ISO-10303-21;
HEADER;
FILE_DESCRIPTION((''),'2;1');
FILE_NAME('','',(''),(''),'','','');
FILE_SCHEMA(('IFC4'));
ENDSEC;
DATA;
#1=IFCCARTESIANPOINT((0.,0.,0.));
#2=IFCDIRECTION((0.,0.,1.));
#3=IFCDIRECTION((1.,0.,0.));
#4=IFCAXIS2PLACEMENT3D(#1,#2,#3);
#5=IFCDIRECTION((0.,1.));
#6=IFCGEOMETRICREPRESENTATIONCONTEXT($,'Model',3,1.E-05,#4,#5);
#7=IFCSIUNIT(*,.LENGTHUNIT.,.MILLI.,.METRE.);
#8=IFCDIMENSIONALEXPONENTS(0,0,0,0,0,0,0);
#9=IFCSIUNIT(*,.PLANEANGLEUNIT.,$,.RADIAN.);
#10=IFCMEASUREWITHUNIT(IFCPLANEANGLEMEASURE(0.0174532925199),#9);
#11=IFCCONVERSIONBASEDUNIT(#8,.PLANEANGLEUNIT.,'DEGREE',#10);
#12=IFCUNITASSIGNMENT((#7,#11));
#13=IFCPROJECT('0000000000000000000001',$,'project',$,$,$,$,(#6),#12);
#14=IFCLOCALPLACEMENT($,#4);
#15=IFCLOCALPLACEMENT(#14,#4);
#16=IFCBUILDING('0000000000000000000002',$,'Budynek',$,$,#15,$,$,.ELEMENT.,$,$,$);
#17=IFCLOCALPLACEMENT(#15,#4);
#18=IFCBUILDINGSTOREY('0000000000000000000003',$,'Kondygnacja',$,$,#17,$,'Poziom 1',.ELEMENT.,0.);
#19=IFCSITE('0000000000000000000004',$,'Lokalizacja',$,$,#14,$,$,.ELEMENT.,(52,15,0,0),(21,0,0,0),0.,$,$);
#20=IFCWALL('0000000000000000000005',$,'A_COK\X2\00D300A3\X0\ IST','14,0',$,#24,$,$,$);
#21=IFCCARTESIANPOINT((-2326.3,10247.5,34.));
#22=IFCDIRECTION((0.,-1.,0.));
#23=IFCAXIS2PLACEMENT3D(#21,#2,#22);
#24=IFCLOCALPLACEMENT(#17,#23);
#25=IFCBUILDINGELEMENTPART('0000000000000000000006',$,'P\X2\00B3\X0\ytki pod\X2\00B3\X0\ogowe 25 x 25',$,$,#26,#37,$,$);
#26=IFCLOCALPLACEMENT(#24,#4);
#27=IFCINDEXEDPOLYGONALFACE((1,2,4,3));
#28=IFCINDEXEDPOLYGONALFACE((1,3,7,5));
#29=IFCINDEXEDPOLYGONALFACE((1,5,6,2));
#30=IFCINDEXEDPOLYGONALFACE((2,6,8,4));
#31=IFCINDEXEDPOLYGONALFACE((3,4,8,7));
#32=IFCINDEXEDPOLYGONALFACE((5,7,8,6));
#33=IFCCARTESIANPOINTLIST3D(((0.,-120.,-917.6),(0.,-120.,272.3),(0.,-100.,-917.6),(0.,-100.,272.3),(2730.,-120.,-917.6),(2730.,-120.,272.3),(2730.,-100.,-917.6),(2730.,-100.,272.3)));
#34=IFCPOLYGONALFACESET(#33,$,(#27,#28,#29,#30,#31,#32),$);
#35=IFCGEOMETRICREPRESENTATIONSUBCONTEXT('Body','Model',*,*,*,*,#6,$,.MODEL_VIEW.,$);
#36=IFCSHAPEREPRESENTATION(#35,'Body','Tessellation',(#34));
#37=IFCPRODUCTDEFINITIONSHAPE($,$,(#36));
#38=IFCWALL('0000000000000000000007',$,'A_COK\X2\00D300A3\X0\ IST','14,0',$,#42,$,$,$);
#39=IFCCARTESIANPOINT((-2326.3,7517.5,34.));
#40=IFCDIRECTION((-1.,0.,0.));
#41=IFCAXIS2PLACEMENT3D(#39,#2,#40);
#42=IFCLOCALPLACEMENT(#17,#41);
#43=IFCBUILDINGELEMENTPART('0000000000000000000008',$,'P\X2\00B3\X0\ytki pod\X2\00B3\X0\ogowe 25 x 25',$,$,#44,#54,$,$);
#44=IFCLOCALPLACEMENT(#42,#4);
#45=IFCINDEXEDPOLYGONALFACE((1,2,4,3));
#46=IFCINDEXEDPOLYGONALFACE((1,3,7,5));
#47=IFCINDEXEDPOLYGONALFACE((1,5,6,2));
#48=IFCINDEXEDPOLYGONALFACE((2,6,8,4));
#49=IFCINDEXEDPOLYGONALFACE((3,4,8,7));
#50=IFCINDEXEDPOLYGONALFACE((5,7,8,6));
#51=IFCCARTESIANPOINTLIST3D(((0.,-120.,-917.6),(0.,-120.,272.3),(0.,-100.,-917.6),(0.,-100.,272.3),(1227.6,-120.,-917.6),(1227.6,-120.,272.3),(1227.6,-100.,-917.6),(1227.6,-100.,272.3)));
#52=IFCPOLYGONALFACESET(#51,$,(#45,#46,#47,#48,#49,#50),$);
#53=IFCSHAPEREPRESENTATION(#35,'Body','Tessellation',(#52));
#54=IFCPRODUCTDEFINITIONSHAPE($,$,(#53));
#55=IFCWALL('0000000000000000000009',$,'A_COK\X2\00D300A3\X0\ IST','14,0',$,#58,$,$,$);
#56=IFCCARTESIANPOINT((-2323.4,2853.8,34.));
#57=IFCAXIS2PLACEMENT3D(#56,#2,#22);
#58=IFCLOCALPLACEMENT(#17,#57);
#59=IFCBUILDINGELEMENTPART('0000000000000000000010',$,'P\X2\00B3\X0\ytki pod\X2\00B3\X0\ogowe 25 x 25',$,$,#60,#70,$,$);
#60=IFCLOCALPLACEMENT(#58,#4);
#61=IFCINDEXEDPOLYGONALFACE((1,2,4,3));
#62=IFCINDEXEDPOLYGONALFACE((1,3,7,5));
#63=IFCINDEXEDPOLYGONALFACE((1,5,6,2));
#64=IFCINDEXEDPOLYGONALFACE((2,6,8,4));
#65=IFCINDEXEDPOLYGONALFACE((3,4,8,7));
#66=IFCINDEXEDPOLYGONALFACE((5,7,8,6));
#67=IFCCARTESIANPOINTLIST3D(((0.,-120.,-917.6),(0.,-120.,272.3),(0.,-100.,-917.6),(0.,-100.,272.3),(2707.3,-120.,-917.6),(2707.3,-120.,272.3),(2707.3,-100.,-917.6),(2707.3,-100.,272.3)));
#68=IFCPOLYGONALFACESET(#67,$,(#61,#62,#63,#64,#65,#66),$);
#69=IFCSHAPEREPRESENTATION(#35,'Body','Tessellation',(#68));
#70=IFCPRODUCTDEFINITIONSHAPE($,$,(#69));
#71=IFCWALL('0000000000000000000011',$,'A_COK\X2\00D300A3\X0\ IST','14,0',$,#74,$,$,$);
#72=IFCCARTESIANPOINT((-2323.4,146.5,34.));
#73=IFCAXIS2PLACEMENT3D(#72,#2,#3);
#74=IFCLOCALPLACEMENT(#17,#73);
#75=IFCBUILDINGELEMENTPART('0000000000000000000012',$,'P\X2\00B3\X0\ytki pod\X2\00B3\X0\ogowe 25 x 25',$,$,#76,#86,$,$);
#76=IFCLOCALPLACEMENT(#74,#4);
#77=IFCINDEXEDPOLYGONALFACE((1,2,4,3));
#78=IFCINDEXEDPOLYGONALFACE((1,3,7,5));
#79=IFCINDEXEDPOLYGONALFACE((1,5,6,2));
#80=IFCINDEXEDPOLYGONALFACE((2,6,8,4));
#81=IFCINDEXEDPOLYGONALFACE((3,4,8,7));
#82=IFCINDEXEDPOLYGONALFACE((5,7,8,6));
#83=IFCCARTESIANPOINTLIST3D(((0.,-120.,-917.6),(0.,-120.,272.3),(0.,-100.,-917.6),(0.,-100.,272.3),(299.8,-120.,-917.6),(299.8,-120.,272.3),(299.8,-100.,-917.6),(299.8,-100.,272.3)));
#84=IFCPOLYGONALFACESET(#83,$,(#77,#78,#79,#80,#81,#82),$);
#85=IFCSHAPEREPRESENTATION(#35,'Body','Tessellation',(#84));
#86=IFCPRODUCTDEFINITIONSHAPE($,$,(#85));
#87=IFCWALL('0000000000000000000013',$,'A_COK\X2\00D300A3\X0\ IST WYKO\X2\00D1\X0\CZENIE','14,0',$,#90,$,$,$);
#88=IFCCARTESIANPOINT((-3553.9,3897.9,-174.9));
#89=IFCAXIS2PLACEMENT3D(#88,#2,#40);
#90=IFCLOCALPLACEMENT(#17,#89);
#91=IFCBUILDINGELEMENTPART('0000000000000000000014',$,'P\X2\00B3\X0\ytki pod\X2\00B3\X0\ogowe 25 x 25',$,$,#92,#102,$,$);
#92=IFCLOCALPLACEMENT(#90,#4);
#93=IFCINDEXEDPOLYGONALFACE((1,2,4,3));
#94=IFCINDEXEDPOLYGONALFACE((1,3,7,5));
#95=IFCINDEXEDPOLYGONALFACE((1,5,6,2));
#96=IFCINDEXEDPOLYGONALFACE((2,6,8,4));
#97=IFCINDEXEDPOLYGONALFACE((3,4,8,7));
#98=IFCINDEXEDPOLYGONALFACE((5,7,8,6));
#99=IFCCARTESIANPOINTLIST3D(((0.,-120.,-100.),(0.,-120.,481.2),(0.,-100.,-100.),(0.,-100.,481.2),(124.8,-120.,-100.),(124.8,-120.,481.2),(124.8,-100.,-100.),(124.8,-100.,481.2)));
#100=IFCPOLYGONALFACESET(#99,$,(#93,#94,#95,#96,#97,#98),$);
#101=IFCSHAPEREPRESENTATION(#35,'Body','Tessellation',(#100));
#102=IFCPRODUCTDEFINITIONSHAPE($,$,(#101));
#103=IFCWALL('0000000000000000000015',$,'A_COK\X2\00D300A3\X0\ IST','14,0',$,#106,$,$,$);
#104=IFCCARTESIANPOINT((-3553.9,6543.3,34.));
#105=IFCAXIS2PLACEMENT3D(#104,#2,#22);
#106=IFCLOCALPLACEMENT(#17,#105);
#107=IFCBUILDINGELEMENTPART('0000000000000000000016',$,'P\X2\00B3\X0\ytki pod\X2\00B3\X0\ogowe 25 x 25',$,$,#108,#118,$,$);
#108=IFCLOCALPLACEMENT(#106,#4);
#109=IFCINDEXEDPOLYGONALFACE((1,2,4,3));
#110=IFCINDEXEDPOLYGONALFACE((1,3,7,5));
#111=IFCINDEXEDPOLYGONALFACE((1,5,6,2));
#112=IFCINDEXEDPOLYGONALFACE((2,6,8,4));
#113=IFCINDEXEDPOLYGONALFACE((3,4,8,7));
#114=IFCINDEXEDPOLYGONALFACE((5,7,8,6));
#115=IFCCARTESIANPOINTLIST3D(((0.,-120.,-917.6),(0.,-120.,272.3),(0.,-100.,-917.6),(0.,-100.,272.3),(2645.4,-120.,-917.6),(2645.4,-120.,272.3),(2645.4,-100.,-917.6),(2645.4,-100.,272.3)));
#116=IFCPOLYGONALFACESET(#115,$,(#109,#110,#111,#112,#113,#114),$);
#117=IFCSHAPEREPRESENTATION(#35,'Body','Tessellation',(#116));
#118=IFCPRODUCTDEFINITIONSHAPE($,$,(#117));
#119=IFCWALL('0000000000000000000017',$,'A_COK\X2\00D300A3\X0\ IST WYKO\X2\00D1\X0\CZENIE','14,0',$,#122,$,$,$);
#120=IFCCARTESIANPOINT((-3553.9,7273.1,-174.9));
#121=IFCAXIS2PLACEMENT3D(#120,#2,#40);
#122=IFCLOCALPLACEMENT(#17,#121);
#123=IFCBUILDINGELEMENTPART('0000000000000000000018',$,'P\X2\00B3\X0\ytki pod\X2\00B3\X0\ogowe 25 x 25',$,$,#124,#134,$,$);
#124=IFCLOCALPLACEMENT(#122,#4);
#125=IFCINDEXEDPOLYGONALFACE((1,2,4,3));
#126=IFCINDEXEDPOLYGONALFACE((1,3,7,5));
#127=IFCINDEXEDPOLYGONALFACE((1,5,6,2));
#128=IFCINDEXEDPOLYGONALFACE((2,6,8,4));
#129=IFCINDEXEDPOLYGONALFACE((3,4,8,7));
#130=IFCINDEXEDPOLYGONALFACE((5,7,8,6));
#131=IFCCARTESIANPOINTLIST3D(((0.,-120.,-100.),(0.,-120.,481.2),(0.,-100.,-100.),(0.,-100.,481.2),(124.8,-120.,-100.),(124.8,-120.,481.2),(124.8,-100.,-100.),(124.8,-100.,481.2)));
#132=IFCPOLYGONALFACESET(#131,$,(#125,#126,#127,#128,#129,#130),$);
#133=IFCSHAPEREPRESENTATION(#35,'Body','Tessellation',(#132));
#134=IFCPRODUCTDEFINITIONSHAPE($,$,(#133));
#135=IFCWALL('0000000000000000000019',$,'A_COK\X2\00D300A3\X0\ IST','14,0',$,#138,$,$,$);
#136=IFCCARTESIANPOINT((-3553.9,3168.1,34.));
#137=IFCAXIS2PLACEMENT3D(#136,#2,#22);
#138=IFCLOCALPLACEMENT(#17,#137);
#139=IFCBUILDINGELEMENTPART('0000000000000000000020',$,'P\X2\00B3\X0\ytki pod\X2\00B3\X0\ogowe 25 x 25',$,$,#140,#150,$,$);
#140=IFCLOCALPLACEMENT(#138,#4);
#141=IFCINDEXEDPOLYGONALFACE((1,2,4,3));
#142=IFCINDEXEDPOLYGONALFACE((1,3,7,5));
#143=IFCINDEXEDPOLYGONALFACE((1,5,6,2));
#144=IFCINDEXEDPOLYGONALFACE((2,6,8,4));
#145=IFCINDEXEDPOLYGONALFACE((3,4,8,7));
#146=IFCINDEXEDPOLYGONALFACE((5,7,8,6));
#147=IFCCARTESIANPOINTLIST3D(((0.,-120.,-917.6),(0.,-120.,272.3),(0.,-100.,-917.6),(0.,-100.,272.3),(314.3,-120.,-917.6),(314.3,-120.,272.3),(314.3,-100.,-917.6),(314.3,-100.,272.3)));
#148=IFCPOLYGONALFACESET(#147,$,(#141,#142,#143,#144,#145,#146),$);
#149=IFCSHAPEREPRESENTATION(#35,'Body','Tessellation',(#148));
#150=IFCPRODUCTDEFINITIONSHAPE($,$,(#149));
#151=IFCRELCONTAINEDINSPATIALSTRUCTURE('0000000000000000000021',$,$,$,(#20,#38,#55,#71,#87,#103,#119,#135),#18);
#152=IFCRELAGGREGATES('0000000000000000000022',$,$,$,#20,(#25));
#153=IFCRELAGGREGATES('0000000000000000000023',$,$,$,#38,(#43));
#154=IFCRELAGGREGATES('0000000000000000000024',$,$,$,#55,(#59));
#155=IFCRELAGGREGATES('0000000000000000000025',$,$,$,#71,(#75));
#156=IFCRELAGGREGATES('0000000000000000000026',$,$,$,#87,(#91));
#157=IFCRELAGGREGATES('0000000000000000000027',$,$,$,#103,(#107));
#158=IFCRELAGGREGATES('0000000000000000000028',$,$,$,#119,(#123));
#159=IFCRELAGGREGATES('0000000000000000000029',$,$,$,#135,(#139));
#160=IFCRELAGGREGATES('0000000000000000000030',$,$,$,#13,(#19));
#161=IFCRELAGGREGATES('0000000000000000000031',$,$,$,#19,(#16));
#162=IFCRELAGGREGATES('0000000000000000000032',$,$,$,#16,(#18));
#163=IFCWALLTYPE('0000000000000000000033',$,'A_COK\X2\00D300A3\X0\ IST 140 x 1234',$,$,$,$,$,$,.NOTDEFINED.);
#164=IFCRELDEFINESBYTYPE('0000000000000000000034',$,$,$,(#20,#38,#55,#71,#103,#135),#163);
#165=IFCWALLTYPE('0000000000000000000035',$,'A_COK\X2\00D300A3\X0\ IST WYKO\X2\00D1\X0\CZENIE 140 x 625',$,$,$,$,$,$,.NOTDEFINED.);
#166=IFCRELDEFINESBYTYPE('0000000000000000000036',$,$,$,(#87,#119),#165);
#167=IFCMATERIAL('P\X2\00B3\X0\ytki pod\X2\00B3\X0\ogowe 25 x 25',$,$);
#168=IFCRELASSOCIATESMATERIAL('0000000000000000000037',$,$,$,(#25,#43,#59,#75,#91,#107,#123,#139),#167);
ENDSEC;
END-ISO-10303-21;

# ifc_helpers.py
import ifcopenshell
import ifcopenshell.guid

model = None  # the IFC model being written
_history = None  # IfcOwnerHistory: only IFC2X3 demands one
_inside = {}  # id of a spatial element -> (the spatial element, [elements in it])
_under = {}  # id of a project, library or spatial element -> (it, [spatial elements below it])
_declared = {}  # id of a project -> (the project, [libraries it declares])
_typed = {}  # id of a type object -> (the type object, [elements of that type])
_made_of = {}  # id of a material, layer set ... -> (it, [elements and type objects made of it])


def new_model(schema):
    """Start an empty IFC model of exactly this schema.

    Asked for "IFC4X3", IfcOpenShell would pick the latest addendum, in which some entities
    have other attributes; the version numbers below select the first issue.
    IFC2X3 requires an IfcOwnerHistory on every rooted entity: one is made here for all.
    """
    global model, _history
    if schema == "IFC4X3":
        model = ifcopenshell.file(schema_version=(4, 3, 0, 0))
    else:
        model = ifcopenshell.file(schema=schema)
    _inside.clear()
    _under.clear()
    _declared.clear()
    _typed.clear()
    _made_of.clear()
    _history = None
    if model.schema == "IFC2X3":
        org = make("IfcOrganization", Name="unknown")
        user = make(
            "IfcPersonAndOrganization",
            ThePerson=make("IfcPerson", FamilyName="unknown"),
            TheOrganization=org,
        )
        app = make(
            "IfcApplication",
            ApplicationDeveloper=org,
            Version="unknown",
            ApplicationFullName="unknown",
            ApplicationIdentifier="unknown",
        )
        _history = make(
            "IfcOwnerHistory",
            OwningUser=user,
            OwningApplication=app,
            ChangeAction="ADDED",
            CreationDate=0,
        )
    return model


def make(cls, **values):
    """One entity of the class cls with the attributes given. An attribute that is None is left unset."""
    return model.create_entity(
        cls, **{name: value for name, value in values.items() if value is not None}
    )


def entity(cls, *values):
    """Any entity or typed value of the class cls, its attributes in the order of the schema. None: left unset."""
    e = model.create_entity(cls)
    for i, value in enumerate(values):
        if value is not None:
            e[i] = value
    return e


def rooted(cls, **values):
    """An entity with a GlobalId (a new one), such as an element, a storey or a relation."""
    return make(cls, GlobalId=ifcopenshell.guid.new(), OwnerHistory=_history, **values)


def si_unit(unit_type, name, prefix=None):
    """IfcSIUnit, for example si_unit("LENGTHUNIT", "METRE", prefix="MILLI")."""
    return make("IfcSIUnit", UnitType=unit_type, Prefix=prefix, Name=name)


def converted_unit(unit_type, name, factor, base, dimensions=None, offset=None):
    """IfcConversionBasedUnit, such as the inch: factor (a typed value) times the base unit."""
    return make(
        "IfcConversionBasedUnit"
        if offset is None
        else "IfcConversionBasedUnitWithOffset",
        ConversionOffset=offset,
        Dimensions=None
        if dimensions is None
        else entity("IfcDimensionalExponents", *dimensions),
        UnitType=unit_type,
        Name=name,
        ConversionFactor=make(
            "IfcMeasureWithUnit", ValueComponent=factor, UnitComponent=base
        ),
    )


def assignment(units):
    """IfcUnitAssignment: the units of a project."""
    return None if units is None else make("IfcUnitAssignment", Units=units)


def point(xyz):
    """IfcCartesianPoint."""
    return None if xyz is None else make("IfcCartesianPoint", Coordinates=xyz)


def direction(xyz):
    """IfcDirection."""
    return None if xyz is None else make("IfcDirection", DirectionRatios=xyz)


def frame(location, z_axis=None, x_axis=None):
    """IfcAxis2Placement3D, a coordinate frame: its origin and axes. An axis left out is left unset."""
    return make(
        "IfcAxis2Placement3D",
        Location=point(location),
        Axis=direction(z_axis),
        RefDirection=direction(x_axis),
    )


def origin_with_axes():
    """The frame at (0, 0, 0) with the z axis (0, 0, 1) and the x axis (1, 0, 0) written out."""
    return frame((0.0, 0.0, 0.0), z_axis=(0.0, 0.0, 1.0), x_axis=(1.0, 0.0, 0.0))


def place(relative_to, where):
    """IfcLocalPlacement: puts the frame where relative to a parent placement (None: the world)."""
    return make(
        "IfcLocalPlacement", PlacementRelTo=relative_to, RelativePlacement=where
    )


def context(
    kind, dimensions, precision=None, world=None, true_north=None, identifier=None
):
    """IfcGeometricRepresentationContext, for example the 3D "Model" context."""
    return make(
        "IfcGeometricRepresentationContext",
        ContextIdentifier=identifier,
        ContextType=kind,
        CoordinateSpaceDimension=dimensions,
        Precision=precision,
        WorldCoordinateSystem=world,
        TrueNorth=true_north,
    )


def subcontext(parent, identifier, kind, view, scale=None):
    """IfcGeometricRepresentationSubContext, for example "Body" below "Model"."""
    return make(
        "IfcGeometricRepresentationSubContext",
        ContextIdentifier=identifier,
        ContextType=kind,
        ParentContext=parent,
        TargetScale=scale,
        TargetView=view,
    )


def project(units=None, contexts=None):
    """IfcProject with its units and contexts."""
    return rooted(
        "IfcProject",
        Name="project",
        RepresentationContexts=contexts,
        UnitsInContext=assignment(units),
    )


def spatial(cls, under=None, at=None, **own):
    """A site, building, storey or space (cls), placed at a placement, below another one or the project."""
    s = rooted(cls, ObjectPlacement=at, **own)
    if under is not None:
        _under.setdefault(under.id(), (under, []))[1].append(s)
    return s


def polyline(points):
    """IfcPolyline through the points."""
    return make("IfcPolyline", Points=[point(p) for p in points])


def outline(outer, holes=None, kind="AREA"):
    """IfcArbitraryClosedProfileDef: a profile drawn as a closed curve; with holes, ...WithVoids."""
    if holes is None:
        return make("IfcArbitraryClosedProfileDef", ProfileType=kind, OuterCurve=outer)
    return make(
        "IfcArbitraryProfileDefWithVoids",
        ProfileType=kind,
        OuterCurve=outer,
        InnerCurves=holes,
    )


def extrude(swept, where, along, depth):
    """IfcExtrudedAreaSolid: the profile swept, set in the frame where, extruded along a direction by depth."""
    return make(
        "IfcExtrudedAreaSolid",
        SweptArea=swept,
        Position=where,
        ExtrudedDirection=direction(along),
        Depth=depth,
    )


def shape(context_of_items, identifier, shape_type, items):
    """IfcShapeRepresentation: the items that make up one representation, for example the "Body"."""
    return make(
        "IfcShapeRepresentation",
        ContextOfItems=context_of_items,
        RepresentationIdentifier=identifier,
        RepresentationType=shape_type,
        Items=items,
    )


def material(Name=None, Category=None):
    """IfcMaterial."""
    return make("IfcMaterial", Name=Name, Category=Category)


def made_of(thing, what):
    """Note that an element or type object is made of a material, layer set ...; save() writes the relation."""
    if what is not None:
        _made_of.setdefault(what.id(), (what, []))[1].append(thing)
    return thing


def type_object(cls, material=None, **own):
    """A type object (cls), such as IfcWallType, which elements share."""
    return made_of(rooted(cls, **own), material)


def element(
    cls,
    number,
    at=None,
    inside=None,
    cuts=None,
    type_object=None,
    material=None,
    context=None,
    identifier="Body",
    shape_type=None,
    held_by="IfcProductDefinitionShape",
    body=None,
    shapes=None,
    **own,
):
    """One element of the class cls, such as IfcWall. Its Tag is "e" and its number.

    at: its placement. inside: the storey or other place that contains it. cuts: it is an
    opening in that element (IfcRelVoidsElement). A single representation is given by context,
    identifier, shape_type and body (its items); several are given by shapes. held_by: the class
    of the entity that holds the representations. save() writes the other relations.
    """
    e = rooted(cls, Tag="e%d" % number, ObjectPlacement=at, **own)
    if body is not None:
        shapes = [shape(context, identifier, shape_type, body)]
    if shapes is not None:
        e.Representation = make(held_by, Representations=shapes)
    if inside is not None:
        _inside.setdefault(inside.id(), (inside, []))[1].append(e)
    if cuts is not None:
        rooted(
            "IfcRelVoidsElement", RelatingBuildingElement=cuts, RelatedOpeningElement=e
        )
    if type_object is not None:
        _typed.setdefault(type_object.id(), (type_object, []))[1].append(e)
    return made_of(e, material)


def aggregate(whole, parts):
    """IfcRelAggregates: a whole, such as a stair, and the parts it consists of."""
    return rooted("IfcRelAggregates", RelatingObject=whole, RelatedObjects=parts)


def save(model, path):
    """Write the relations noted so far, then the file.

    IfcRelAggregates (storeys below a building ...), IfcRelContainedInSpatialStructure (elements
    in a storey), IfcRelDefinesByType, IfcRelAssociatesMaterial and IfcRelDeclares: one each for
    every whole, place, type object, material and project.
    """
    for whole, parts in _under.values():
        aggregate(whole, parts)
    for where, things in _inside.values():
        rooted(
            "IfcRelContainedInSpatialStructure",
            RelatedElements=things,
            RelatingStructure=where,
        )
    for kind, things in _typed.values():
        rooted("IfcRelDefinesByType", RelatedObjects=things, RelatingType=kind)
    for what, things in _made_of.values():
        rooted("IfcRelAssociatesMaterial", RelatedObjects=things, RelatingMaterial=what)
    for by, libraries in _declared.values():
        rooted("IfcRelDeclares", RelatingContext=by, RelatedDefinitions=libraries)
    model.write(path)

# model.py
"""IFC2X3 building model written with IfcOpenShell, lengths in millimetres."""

from ifc_helpers import new_model, entity, si_unit, converted_unit, direction, frame, origin_with_axes, place, context, subcontext, project, spatial, polyline, outline, extrude, material, type_object, element, aggregate, save


model = new_model("IFC2X3")

# Units and contexts
model_context = context("Model", 3, precision=1e-05, world=origin_with_axes(), true_north=direction((0.0, 1.0)))
body_context = subcontext(model_context, "Body", "Model", "MODEL_VIEW")
ifc_project = project(units=[si_unit("LENGTHUNIT", "METRE", prefix="MILLI"), converted_unit("PLANEANGLEUNIT", "DEGREE", entity("IfcPlaneAngleMeasure", 0.0174532925199), si_unit("PLANEANGLEUNIT", "RADIAN"), dimensions=[0, 0, 0, 0, 0, 0, 0])], contexts=[model_context])

# Site, building, storey
site_placement = place(None, origin_with_axes())
site = spatial("IfcSite", under=ifc_project, at=site_placement, Name="Lokalizacja", CompositionType="ELEMENT", RefLatitude=(52, 15, 0, 0), RefLongitude=(21, 0, 0, 0), RefElevation=0.0)
building_placement = place(site_placement, origin_with_axes())
building = spatial("IfcBuilding", under=site, at=building_placement, Name="Budynek", CompositionType="ELEMENT")
storey_placement = place(building_placement, origin_with_axes())
storey = spatial("IfcBuildingStorey", under=building, at=storey_placement, Name="Kondygnacja", LongName="Poziom 1", CompositionType="ELEMENT", Elevation=0.0)

# Walls, building element parts
wall_type_1 = type_object("IfcWallType", Name="A_COKÓ£ IST 140 x 1234", PredefinedType="NOTDEFINED")
wall_1_placement = place(storey_placement, frame((-2326.3, 10247.5, 34.0), z_axis=(0.0, 0.0, 1.0), x_axis=(0.0, -1.0, 0.0)))
wall_1 = element("IfcWall", 1, at=wall_1_placement, inside=storey, type_object=wall_type_1, Name="A_COKÓ£ IST", Description="14,0")
ifc_material_1 = material(Name="P³ytki pod³ogowe 25 x 25")
building_element_part_1_placement = place(wall_1_placement, origin_with_axes())
building_element_part_1 = element("IfcBuildingElementPart", 2, at=building_element_part_1_placement, material=ifc_material_1, Name="P³ytki pod³ogowe 25 x 25", context=body_context, shape_type="SweptSolid", body=[
    extrude(outline(polyline([(-100.0, -917.6), (-100.0, 272.3), (-120.0, 272.3), (-120.0, -917.6), (-100.0, -917.6)])), frame((0.0, 0.0, 0.0), z_axis=(1.0, 0.0, 0.0), x_axis=(0.0, 1.0, 0.0)), (0.0, 0.0, 1.0), 2730.0),
])
aggregate(wall_1, [building_element_part_1])
wall_2_placement = place(storey_placement, frame((-2326.3, 7517.5, 34.0), z_axis=(0.0, 0.0, 1.0), x_axis=(-1.0, 0.0, 0.0)))
wall_2 = element("IfcWall", 3, at=wall_2_placement, inside=storey, type_object=wall_type_1, Name="A_COKÓ£ IST", Description="14,0")
building_element_part_2_placement = place(wall_2_placement, origin_with_axes())
building_element_part_2 = element("IfcBuildingElementPart", 4, at=building_element_part_2_placement, material=ifc_material_1, Name="P³ytki pod³ogowe 25 x 25", context=body_context, shape_type="SweptSolid", body=[
    extrude(outline(polyline([(-100.0, -917.6), (-100.0, 272.3), (-120.0, 272.3), (-120.0, -917.6), (-100.0, -917.6)])), frame((0.0, 0.0, 0.0), z_axis=(1.0, 0.0, 0.0), x_axis=(0.0, 1.0, 0.0)), (0.0, 0.0, 1.0), 1227.6),
])
aggregate(wall_2, [building_element_part_2])
wall_3_placement = place(storey_placement, frame((-2323.4, 2853.8, 34.0), z_axis=(0.0, 0.0, 1.0), x_axis=(0.0, -1.0, 0.0)))
wall_3 = element("IfcWall", 5, at=wall_3_placement, inside=storey, type_object=wall_type_1, Name="A_COKÓ£ IST", Description="14,0")
building_element_part_3_placement = place(wall_3_placement, origin_with_axes())
building_element_part_3 = element("IfcBuildingElementPart", 6, at=building_element_part_3_placement, material=ifc_material_1, Name="P³ytki pod³ogowe 25 x 25", context=body_context, shape_type="SweptSolid", body=[
    extrude(outline(polyline([(-100.0, -917.6), (-100.0, 272.3), (-120.0, 272.3), (-120.0, -917.6), (-100.0, -917.6)])), frame((0.0, 0.0, 0.0), z_axis=(1.0, 0.0, 0.0), x_axis=(0.0, 1.0, 0.0)), (0.0, 0.0, 1.0), 2707.3),
])
aggregate(wall_3, [building_element_part_3])
wall_4_placement = place(storey_placement, frame((-2323.4, 146.5, 34.0), z_axis=(0.0, 0.0, 1.0), x_axis=(1.0, 0.0, 0.0)))
wall_4 = element("IfcWall", 7, at=wall_4_placement, inside=storey, type_object=wall_type_1, Name="A_COKÓ£ IST", Description="14,0")
building_element_part_4_placement = place(wall_4_placement, origin_with_axes())
building_element_part_4 = element("IfcBuildingElementPart", 8, at=building_element_part_4_placement, material=ifc_material_1, Name="P³ytki pod³ogowe 25 x 25", context=body_context, shape_type="SweptSolid", body=[
    extrude(outline(polyline([(-100.0, -917.6), (-100.0, 272.3), (-120.0, 272.3), (-120.0, -917.6), (-100.0, -917.6)])), frame((0.0, 0.0, 0.0), z_axis=(1.0, 0.0, 0.0), x_axis=(0.0, 1.0, 0.0)), (0.0, 0.0, 1.0), 299.8),
])
aggregate(wall_4, [building_element_part_4])

# Wall, building element part
wall_type_2 = type_object("IfcWallType", Name="A_COKÓ£ IST WYKOÑCZENIE 140 x 625", PredefinedType="NOTDEFINED")
wall_5_placement = place(storey_placement, frame((-3553.9, 3897.9, -174.9), z_axis=(0.0, 0.0, 1.0), x_axis=(-1.0, 0.0, 0.0)))
wall_5 = element("IfcWall", 9, at=wall_5_placement, inside=storey, type_object=wall_type_2, Name="A_COKÓ£ IST WYKOÑCZENIE", Description="14,0")
building_element_part_5_placement = place(wall_5_placement, origin_with_axes())
building_element_part_5 = element("IfcBuildingElementPart", 10, at=building_element_part_5_placement, material=ifc_material_1, Name="P³ytki pod³ogowe 25 x 25", context=body_context, shape_type="SweptSolid", body=[
    extrude(outline(polyline([(-100.0, -100.0), (-100.0, 481.2), (-120.0, 481.2), (-120.0, -100.0), (-100.0, -100.0)])), frame((0.0, 0.0, 0.0), z_axis=(1.0, 0.0, 0.0), x_axis=(0.0, 1.0, 0.0)), (0.0, 0.0, 1.0), 124.8),
])
aggregate(wall_5, [building_element_part_5])

# Walls, building element parts
wall_6_placement = place(storey_placement, frame((-3553.9, 6543.3, 34.0), z_axis=(0.0, 0.0, 1.0), x_axis=(0.0, -1.0, 0.0)))
wall_6 = element("IfcWall", 11, at=wall_6_placement, inside=storey, type_object=wall_type_1, Name="A_COKÓ£ IST", Description="14,0")
building_element_part_6_placement = place(wall_6_placement, origin_with_axes())
building_element_part_6 = element("IfcBuildingElementPart", 12, at=building_element_part_6_placement, material=ifc_material_1, Name="P³ytki pod³ogowe 25 x 25", context=body_context, shape_type="SweptSolid", body=[
    extrude(outline(polyline([(-100.0, -917.6), (-100.0, 272.3), (-120.0, 272.3), (-120.0, -917.6), (-100.0, -917.6)])), frame((0.0, 0.0, 0.0), z_axis=(1.0, 0.0, 0.0), x_axis=(0.0, 1.0, 0.0)), (0.0, 0.0, 1.0), 2645.4),
])
aggregate(wall_6, [building_element_part_6])
wall_7_placement = place(storey_placement, frame((-3553.9, 7273.1, -174.9), z_axis=(0.0, 0.0, 1.0), x_axis=(-1.0, 0.0, 0.0)))
wall_7 = element("IfcWall", 13, at=wall_7_placement, inside=storey, type_object=wall_type_2, Name="A_COKÓ£ IST WYKOÑCZENIE", Description="14,0")
building_element_part_7_placement = place(wall_7_placement, origin_with_axes())
building_element_part_7 = element("IfcBuildingElementPart", 14, at=building_element_part_7_placement, material=ifc_material_1, Name="P³ytki pod³ogowe 25 x 25", context=body_context, shape_type="SweptSolid", body=[
    extrude(outline(polyline([(-100.0, -100.0), (-100.0, 481.2), (-120.0, 481.2), (-120.0, -100.0), (-100.0, -100.0)])), frame((0.0, 0.0, 0.0), z_axis=(1.0, 0.0, 0.0), x_axis=(0.0, 1.0, 0.0)), (0.0, 0.0, 1.0), 124.8),
])
aggregate(wall_7, [building_element_part_7])
wall_8_placement = place(storey_placement, frame((-3553.9, 3168.1, 34.0), z_axis=(0.0, 0.0, 1.0), x_axis=(0.0, -1.0, 0.0)))
wall_8 = element("IfcWall", 15, at=wall_8_placement, inside=storey, type_object=wall_type_1, Name="A_COKÓ£ IST", Description="14,0")
building_element_part_8_placement = place(wall_8_placement, origin_with_axes())
building_element_part_8 = element("IfcBuildingElementPart", 16, at=building_element_part_8_placement, material=ifc_material_1, Name="P³ytki pod³ogowe 25 x 25", context=body_context, shape_type="SweptSolid", body=[
    extrude(outline(polyline([(-100.0, -917.6), (-100.0, 272.3), (-120.0, 272.3), (-120.0, -917.6), (-100.0, -917.6)])), frame((0.0, 0.0, 0.0), z_axis=(1.0, 0.0, 0.0), x_axis=(0.0, 1.0, 0.0)), (0.0, 0.0, 1.0), 314.3),
])
aggregate(wall_8, [building_element_part_8])

save(model, "model.ifc")
